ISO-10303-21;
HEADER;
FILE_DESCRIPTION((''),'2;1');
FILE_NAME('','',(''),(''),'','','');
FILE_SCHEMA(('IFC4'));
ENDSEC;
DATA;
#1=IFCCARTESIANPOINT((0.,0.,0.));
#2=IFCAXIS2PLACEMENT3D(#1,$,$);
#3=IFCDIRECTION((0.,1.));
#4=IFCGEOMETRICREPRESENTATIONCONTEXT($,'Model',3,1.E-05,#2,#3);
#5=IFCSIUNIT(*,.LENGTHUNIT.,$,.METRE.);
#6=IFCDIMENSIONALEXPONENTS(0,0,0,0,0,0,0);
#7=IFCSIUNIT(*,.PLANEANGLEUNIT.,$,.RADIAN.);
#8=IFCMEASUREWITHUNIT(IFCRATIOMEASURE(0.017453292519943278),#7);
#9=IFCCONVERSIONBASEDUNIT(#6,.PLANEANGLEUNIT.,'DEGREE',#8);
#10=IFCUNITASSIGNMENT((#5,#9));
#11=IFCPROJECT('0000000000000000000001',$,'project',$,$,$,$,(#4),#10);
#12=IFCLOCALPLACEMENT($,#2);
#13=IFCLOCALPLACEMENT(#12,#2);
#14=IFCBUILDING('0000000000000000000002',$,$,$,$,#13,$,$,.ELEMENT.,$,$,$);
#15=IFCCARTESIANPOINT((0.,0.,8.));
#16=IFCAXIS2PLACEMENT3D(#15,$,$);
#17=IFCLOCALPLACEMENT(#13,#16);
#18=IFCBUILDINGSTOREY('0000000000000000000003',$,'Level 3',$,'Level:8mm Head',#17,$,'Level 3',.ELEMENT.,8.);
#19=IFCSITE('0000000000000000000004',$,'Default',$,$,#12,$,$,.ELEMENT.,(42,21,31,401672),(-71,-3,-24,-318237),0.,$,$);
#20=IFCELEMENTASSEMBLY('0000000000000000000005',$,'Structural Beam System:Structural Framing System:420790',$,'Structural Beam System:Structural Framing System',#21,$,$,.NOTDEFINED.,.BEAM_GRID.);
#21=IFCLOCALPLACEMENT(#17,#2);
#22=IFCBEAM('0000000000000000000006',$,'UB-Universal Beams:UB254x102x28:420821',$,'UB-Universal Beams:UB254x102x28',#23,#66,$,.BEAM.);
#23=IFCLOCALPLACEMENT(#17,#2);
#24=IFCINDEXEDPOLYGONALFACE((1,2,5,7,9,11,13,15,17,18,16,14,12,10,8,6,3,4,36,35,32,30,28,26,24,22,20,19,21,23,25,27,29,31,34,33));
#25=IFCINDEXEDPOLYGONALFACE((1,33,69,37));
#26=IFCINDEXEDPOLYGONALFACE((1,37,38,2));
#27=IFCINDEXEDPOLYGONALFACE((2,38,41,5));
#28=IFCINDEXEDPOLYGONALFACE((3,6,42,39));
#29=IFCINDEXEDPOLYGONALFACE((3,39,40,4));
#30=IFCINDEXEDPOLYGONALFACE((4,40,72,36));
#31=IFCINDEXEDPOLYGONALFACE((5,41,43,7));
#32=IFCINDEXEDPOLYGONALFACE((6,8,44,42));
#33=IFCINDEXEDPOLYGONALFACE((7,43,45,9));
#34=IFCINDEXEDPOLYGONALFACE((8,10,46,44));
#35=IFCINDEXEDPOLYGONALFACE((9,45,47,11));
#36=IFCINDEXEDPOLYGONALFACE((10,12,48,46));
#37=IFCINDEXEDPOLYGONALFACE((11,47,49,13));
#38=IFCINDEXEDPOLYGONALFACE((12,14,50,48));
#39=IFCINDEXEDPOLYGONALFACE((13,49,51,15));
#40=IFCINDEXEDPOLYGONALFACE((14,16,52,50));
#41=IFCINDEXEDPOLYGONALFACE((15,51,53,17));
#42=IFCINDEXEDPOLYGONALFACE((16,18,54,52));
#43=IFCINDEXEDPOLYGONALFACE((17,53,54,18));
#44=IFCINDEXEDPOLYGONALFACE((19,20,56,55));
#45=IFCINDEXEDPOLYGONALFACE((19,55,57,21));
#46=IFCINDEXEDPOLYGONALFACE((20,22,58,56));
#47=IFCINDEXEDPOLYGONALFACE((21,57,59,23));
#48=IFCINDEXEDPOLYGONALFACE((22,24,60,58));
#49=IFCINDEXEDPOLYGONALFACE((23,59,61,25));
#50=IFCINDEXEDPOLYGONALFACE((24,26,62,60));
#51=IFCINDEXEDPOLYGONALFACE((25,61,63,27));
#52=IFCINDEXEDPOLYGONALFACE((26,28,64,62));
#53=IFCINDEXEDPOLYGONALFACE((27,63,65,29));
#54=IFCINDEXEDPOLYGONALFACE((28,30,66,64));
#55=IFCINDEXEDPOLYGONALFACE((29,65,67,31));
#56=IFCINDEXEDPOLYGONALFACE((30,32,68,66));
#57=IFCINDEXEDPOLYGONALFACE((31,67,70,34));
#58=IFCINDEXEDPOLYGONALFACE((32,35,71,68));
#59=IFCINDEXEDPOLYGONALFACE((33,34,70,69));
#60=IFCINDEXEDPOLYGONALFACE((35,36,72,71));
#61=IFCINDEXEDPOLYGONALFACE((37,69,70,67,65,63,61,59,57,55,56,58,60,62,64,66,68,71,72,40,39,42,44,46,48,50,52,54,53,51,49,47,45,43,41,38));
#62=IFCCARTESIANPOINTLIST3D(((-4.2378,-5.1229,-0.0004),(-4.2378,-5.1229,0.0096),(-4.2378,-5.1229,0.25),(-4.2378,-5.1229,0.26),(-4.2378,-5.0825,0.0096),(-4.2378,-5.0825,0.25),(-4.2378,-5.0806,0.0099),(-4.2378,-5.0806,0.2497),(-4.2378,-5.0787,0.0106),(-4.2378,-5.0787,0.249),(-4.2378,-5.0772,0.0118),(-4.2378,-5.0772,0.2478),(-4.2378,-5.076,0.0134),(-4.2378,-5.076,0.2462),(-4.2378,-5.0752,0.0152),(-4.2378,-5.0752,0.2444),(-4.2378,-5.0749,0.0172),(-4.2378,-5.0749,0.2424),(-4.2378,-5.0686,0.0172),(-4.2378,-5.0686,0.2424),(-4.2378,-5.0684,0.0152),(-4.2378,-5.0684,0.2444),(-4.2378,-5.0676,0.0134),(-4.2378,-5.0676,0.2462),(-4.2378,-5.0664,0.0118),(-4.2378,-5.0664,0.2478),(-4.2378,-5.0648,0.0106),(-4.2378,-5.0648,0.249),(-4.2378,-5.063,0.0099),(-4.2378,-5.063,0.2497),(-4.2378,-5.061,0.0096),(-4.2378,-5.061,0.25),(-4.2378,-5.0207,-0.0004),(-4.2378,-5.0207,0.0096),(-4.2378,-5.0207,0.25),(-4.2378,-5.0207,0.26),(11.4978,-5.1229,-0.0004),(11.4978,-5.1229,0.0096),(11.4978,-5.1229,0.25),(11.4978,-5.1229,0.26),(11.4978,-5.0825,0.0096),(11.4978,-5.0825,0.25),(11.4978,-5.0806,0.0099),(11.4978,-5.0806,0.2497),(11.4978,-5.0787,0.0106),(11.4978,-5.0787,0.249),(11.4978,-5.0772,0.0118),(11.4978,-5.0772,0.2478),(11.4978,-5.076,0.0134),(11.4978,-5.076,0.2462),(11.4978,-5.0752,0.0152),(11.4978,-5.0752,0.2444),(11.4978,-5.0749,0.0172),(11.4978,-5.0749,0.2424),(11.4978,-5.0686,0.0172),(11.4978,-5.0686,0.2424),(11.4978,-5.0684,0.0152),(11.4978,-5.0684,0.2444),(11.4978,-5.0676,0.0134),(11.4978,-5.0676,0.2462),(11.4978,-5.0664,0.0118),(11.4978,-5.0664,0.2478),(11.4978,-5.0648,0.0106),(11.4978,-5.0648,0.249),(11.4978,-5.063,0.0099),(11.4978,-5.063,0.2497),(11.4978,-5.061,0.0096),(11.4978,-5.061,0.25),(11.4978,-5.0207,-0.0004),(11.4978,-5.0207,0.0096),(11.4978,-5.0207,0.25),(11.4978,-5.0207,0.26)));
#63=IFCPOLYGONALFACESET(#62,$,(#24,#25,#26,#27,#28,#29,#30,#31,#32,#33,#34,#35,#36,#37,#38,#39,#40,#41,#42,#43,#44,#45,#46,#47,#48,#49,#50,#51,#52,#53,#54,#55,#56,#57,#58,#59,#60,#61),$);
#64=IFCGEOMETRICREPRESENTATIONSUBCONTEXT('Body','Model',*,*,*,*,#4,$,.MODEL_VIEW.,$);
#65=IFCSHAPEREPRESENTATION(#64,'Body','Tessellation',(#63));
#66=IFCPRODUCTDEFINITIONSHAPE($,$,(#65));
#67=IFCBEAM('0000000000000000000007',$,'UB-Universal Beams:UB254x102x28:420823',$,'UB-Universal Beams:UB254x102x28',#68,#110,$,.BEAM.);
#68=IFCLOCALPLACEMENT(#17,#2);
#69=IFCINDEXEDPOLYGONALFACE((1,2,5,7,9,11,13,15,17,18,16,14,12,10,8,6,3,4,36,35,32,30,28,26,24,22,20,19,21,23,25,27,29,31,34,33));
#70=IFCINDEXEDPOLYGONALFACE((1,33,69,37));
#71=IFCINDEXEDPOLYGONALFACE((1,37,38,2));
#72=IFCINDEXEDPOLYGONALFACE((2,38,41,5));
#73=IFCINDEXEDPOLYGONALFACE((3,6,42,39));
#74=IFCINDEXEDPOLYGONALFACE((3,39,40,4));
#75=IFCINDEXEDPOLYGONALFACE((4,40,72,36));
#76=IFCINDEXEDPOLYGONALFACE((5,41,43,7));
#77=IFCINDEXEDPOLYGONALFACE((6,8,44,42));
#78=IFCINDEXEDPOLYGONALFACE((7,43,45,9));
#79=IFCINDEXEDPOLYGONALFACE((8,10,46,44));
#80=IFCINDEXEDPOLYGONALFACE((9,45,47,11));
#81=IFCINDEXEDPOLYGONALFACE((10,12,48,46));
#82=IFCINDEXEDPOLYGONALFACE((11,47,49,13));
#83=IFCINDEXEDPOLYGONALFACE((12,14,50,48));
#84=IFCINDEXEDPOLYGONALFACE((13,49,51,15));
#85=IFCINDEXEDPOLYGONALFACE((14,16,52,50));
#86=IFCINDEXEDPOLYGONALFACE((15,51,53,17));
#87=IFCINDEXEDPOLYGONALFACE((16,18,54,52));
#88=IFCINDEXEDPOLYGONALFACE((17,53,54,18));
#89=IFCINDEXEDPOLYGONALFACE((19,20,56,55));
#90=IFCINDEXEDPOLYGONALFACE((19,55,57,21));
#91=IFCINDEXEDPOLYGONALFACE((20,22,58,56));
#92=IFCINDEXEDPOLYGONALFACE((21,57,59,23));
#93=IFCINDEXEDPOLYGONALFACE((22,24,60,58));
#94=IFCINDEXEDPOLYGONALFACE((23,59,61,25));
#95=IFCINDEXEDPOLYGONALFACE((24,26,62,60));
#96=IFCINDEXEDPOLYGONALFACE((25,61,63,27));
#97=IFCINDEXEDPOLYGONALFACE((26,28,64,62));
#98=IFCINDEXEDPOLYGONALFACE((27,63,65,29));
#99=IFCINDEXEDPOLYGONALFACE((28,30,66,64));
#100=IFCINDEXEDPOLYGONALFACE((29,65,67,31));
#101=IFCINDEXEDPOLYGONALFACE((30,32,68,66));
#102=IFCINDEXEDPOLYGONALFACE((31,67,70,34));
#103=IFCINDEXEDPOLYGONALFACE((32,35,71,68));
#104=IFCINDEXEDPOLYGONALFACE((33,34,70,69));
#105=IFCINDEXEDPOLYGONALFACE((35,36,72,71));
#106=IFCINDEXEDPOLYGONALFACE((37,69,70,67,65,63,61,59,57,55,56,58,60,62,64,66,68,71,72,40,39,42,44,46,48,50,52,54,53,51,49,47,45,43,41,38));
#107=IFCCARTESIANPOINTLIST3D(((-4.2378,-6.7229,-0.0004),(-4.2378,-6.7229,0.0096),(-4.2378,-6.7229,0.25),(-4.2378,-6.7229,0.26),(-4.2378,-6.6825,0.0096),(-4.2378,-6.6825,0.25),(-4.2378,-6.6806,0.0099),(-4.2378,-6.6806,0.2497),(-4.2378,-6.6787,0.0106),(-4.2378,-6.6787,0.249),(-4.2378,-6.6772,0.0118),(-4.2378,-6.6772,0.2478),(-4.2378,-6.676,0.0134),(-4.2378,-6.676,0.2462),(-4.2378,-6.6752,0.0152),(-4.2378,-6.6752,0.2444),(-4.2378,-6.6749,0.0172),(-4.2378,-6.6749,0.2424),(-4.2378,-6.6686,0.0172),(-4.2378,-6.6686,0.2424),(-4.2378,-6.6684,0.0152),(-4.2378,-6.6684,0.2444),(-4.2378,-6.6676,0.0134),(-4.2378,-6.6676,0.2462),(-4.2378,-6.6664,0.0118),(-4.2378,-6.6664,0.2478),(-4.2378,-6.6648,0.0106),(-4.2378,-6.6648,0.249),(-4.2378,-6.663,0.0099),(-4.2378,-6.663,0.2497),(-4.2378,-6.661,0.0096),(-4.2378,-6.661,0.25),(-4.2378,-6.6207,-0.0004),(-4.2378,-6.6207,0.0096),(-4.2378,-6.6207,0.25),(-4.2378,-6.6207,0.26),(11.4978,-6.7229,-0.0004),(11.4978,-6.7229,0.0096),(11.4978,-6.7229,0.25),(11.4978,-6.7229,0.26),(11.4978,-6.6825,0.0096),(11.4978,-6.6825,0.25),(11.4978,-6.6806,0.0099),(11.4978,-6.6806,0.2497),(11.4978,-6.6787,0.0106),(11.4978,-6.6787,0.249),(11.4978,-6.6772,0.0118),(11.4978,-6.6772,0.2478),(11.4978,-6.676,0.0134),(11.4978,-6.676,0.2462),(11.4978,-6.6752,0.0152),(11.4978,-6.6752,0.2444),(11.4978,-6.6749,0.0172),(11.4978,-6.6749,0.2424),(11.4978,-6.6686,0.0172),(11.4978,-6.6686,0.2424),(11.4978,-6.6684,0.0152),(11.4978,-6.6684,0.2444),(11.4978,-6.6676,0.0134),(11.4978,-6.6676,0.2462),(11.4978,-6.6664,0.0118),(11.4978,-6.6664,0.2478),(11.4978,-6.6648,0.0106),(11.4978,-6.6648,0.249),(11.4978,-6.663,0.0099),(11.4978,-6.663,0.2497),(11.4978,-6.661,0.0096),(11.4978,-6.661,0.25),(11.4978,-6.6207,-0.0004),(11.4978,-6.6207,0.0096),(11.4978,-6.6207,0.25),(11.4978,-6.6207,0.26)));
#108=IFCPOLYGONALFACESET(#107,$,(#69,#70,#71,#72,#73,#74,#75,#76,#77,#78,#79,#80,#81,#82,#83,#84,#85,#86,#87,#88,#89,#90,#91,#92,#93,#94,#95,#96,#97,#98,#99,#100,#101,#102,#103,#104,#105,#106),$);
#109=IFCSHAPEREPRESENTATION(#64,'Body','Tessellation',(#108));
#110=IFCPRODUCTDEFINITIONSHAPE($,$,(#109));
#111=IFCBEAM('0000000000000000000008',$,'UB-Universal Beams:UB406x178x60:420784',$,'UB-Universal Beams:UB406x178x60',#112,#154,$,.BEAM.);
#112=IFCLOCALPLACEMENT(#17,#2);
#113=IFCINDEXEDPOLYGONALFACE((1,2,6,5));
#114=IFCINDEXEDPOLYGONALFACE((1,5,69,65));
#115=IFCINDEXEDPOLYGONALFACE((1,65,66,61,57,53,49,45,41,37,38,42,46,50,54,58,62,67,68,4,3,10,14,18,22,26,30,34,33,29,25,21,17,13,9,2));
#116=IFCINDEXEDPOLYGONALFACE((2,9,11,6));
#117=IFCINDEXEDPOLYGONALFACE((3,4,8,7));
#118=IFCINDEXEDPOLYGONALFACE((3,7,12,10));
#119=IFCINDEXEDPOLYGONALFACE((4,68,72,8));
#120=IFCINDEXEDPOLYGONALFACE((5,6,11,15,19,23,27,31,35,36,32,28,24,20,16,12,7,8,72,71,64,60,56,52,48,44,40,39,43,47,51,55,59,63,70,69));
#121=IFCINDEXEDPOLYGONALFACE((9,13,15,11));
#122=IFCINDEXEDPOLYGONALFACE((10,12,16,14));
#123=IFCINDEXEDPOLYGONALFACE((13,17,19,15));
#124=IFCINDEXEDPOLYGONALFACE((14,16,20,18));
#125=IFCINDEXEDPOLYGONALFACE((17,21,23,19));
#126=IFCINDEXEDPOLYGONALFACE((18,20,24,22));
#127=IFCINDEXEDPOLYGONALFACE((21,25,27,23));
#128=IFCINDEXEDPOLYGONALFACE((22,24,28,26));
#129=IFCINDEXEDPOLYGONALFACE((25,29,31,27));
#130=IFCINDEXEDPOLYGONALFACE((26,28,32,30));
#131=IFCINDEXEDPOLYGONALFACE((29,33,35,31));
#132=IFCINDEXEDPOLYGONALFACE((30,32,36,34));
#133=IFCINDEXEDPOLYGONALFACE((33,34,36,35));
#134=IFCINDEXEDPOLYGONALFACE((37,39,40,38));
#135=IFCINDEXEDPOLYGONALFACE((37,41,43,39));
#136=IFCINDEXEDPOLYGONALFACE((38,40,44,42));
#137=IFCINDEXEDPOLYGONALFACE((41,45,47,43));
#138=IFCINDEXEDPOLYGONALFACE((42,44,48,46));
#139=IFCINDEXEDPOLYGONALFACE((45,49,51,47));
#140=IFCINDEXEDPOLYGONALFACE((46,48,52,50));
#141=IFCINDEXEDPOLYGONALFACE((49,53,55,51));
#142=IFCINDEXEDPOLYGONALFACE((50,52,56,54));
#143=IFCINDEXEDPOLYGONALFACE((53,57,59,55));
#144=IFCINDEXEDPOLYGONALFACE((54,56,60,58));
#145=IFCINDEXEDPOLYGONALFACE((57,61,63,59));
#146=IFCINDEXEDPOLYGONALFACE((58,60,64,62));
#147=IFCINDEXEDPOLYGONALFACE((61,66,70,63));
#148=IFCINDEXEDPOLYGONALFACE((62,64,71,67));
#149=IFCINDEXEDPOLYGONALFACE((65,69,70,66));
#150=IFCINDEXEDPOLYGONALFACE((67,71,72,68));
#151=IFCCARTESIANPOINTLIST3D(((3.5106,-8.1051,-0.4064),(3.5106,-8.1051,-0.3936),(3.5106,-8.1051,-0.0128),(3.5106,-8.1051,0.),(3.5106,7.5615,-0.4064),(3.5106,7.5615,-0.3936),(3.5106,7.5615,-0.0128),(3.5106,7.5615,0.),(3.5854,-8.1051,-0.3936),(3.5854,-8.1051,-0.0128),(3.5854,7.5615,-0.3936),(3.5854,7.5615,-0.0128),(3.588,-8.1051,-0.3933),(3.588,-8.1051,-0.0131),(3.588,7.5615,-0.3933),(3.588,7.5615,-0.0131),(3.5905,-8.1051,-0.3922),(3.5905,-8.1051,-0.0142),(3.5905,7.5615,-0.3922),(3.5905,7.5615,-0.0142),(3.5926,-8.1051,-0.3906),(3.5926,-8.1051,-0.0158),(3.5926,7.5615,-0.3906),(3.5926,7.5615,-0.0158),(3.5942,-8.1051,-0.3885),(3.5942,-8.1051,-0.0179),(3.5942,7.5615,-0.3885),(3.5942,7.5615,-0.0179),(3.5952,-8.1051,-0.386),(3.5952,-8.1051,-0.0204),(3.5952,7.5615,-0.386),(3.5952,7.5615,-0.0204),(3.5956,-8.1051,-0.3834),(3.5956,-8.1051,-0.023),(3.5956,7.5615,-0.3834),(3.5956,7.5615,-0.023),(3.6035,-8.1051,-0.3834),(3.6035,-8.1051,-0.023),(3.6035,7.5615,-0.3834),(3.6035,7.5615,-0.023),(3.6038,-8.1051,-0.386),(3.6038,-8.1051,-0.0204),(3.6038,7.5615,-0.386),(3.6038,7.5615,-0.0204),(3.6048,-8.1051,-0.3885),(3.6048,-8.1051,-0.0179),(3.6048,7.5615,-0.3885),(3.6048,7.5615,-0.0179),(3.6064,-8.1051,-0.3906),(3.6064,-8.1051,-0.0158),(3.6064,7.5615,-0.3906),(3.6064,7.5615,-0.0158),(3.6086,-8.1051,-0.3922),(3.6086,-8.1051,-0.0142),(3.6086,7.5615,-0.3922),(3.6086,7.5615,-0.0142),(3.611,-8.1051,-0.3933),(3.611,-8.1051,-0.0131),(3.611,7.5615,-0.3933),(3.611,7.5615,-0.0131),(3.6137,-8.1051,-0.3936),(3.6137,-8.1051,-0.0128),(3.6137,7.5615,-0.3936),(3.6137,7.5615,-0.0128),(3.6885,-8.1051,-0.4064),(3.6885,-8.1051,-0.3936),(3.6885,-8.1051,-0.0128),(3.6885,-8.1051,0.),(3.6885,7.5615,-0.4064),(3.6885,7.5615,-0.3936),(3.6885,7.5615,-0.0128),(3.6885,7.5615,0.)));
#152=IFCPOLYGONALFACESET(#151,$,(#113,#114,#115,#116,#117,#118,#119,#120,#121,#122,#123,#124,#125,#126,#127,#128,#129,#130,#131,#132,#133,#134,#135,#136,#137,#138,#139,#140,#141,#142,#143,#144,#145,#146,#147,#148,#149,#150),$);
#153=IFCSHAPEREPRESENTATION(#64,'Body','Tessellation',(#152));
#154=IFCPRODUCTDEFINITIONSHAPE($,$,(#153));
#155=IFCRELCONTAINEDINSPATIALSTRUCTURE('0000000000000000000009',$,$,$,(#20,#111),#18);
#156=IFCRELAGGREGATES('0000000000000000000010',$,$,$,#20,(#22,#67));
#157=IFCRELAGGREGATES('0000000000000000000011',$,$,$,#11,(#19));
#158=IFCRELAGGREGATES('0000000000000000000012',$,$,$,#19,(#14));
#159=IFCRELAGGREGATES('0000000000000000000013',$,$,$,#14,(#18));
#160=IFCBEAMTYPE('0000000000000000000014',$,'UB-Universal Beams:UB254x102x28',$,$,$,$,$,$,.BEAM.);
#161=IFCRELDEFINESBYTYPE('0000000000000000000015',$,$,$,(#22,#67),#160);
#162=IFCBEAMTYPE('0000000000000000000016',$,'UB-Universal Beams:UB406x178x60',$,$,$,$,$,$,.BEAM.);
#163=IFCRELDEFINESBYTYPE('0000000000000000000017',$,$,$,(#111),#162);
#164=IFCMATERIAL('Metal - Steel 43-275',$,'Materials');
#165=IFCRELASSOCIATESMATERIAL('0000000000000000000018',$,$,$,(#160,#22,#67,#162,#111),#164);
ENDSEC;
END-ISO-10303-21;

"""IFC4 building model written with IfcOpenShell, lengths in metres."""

from ifc_helpers import new_model, entity, si_unit, converted_unit, direction, frame, origin, place, context, subcontext, project, spatial, line, arc, indexed_curve, outline, extrude, source, transform, mapped, material, type_object, type_shapes, element, aggregate, save


model = new_model("IFC4")

# Units and contexts
model_context = context("Model", 3, precision=1e-05, world=origin(), true_north=direction((0.0, 1.0)))
body_context = subcontext(model_context, "Body", "Model", "MODEL_VIEW")
ifc_project = project(units=[si_unit("LENGTHUNIT", "METRE"), converted_unit("PLANEANGLEUNIT", "DEGREE", entity("IfcRatioMeasure", 0.017453292519943278), si_unit("PLANEANGLEUNIT", "RADIAN"), dimensions=[0, 0, 0, 0, 0, 0, 0])], contexts=[model_context])

# Site, building, storey
site_placement = place(None, origin())
site = spatial("IfcSite", under=ifc_project, at=site_placement, Name="Default", CompositionType="ELEMENT", RefLatitude=(42, 21, 31, 401672), RefLongitude=(-71, -3, -24, -318237), RefElevation=0.0)
building_placement = place(site_placement, origin())
building = spatial("IfcBuilding", under=site, at=building_placement, CompositionType="ELEMENT")
storey_placement = place(building_placement, frame((0.0, 0.0, 8.0)))
storey = spatial("IfcBuildingStorey", under=building, at=storey_placement, Name="Level 3", ObjectType="Level:8mm Head", LongName="Level 3", CompositionType="ELEMENT", Elevation=8.0)

# Shared definitions
ifc_material_1 = material(Name="Metal - Steel 43-275", Category="Materials")

# Element assembly, beams
assembly_placement = place(storey_placement, origin())
assembly = element("IfcElementAssembly", 1, at=assembly_placement, inside=storey, Name="Structural Beam System:Structural Framing System:420790", ObjectType="Structural Beam System:Structural Framing System", AssemblyPlace="NOTDEFINED", PredefinedType="BEAM_GRID")
beam_type_1 = type_object("IfcBeamType", Name="UB-Universal Beams:UB254x102x28", PredefinedType="BEAM", material=ifc_material_1)
shared_shape_1 = source(origin(), body_context, "Body", "SweptSolid", [
    extrude(outline(indexed_curve([(-0.1302, -0.0511), (-0.1202, -0.0511), (-0.1202, -0.0107), (-0.118, -0.0054), (-0.1126, -0.0031), (0.1126, -0.0031), (0.118, -0.0054), (0.1202, -0.0107), (0.1202, -0.0511), (0.1302, -0.0511), (0.1302, 0.0511), (0.1202, 0.0511), (0.1202, 0.0108), (0.118, 0.0054), (0.1126, 0.0032), (-0.1126, 0.0032), (-0.118, 0.0054), (-0.1202, 0.0108), (-0.1202, 0.0511), (-0.1302, 0.0511)], segments=[line(1, 2, 3), arc(3, 4, 5), line(5, 6), arc(6, 7, 8), line(8, 9, 10, 11, 12, 13), arc(13, 14, 15), line(15, 16), arc(16, 17, 18), line(18, 19, 20, 1)], self_intersect=False)), frame((-7.8373, 0.0, 0.0), z_axis=(1.0, 0.0, 0.0), x_axis=(0.0, 0.0, -1.0)), (0.0, 0.0, 1.0), 15.7356),
])
type_shapes(beam_type_1, [shared_shape_1])
beam_1_placement = place(assembly_placement, frame((3.5995, -5.0718, 0.1298)))
beam_1 = element("IfcBeam", 2, at=beam_1_placement, type_object=beam_type_1, material=ifc_material_1, Name="UB-Universal Beams:UB254x102x28:420821", ObjectType="UB-Universal Beams:UB254x102x28", PredefinedType="BEAM", context=body_context, shape_type="MappedRepresentation", body=[
    mapped(shared_shape_1, transform((0.0, 0.0, 0.0), scale=1.0)),
])
beam_2_placement = place(assembly_placement, frame((3.5995, -6.6718, 0.1298)))
beam_2 = element("IfcBeam", 3, at=beam_2_placement, type_object=beam_type_1, material=ifc_material_1, Name="UB-Universal Beams:UB254x102x28:420823", ObjectType="UB-Universal Beams:UB254x102x28", PredefinedType="BEAM", context=body_context, shape_type="MappedRepresentation", body=[
    mapped(shared_shape_1, transform((0.0, 0.0, 0.0), scale=1.0)),
])
aggregate(assembly, [beam_1, beam_2])

# Beam
beam_type_2 = type_object("IfcBeamType", Name="UB-Universal Beams:UB406x178x60", PredefinedType="BEAM", material=ifc_material_1)
shared_shape_2 = source(origin(), body_context, "Body", "SweptSolid", [
    extrude(outline(indexed_curve([(-0.089, -0.2032), (0.0889, -0.2032), (0.0889, -0.1904), (0.0141, -0.1904), (0.0069, -0.1874), (0.0039, -0.1802), (0.0039, 0.1802), (0.0069, 0.1874), (0.0141, 0.1904), (0.0889, 0.1904), (0.0889, 0.2032), (-0.089, 0.2032), (-0.089, 0.1904), (-0.0142, 0.1904), (-0.0069, 0.1874), (-0.004, 0.1802), (-0.004, -0.1802), (-0.0069, -0.1874), (-0.0142, -0.1904), (-0.089, -0.1904)], segments=[line(1, 2, 3, 4), arc(4, 5, 6), line(6, 7), arc(7, 8, 9), line(9, 10, 11, 12, 13, 14), arc(14, 15, 16), line(16, 17), arc(17, 18, 19), line(19, 20, 1)], self_intersect=False)), frame((3.5995, -8.1051, 7.7968), z_axis=(0.0, 1.0, 0.0), x_axis=(-1.0, 0.0, 0.0)), (0.0, 0.0, 1.0), 15.6666),
])
type_shapes(beam_type_2, [shared_shape_2])
beam_3_placement = place(storey_placement, frame((0.0, 0.0, -8.0)))
element("IfcBeam", 4, at=beam_3_placement, inside=storey, type_object=beam_type_2, material=ifc_material_1, Name="UB-Universal Beams:UB406x178x60:420784", ObjectType="UB-Universal Beams:UB406x178x60", PredefinedType="BEAM", context=body_context, shape_type="MappedRepresentation", body=[
    mapped(shared_shape_2, transform((0.0, 0.0, 0.0), scale=1.0)),
])

save(model, "model.ifc")
